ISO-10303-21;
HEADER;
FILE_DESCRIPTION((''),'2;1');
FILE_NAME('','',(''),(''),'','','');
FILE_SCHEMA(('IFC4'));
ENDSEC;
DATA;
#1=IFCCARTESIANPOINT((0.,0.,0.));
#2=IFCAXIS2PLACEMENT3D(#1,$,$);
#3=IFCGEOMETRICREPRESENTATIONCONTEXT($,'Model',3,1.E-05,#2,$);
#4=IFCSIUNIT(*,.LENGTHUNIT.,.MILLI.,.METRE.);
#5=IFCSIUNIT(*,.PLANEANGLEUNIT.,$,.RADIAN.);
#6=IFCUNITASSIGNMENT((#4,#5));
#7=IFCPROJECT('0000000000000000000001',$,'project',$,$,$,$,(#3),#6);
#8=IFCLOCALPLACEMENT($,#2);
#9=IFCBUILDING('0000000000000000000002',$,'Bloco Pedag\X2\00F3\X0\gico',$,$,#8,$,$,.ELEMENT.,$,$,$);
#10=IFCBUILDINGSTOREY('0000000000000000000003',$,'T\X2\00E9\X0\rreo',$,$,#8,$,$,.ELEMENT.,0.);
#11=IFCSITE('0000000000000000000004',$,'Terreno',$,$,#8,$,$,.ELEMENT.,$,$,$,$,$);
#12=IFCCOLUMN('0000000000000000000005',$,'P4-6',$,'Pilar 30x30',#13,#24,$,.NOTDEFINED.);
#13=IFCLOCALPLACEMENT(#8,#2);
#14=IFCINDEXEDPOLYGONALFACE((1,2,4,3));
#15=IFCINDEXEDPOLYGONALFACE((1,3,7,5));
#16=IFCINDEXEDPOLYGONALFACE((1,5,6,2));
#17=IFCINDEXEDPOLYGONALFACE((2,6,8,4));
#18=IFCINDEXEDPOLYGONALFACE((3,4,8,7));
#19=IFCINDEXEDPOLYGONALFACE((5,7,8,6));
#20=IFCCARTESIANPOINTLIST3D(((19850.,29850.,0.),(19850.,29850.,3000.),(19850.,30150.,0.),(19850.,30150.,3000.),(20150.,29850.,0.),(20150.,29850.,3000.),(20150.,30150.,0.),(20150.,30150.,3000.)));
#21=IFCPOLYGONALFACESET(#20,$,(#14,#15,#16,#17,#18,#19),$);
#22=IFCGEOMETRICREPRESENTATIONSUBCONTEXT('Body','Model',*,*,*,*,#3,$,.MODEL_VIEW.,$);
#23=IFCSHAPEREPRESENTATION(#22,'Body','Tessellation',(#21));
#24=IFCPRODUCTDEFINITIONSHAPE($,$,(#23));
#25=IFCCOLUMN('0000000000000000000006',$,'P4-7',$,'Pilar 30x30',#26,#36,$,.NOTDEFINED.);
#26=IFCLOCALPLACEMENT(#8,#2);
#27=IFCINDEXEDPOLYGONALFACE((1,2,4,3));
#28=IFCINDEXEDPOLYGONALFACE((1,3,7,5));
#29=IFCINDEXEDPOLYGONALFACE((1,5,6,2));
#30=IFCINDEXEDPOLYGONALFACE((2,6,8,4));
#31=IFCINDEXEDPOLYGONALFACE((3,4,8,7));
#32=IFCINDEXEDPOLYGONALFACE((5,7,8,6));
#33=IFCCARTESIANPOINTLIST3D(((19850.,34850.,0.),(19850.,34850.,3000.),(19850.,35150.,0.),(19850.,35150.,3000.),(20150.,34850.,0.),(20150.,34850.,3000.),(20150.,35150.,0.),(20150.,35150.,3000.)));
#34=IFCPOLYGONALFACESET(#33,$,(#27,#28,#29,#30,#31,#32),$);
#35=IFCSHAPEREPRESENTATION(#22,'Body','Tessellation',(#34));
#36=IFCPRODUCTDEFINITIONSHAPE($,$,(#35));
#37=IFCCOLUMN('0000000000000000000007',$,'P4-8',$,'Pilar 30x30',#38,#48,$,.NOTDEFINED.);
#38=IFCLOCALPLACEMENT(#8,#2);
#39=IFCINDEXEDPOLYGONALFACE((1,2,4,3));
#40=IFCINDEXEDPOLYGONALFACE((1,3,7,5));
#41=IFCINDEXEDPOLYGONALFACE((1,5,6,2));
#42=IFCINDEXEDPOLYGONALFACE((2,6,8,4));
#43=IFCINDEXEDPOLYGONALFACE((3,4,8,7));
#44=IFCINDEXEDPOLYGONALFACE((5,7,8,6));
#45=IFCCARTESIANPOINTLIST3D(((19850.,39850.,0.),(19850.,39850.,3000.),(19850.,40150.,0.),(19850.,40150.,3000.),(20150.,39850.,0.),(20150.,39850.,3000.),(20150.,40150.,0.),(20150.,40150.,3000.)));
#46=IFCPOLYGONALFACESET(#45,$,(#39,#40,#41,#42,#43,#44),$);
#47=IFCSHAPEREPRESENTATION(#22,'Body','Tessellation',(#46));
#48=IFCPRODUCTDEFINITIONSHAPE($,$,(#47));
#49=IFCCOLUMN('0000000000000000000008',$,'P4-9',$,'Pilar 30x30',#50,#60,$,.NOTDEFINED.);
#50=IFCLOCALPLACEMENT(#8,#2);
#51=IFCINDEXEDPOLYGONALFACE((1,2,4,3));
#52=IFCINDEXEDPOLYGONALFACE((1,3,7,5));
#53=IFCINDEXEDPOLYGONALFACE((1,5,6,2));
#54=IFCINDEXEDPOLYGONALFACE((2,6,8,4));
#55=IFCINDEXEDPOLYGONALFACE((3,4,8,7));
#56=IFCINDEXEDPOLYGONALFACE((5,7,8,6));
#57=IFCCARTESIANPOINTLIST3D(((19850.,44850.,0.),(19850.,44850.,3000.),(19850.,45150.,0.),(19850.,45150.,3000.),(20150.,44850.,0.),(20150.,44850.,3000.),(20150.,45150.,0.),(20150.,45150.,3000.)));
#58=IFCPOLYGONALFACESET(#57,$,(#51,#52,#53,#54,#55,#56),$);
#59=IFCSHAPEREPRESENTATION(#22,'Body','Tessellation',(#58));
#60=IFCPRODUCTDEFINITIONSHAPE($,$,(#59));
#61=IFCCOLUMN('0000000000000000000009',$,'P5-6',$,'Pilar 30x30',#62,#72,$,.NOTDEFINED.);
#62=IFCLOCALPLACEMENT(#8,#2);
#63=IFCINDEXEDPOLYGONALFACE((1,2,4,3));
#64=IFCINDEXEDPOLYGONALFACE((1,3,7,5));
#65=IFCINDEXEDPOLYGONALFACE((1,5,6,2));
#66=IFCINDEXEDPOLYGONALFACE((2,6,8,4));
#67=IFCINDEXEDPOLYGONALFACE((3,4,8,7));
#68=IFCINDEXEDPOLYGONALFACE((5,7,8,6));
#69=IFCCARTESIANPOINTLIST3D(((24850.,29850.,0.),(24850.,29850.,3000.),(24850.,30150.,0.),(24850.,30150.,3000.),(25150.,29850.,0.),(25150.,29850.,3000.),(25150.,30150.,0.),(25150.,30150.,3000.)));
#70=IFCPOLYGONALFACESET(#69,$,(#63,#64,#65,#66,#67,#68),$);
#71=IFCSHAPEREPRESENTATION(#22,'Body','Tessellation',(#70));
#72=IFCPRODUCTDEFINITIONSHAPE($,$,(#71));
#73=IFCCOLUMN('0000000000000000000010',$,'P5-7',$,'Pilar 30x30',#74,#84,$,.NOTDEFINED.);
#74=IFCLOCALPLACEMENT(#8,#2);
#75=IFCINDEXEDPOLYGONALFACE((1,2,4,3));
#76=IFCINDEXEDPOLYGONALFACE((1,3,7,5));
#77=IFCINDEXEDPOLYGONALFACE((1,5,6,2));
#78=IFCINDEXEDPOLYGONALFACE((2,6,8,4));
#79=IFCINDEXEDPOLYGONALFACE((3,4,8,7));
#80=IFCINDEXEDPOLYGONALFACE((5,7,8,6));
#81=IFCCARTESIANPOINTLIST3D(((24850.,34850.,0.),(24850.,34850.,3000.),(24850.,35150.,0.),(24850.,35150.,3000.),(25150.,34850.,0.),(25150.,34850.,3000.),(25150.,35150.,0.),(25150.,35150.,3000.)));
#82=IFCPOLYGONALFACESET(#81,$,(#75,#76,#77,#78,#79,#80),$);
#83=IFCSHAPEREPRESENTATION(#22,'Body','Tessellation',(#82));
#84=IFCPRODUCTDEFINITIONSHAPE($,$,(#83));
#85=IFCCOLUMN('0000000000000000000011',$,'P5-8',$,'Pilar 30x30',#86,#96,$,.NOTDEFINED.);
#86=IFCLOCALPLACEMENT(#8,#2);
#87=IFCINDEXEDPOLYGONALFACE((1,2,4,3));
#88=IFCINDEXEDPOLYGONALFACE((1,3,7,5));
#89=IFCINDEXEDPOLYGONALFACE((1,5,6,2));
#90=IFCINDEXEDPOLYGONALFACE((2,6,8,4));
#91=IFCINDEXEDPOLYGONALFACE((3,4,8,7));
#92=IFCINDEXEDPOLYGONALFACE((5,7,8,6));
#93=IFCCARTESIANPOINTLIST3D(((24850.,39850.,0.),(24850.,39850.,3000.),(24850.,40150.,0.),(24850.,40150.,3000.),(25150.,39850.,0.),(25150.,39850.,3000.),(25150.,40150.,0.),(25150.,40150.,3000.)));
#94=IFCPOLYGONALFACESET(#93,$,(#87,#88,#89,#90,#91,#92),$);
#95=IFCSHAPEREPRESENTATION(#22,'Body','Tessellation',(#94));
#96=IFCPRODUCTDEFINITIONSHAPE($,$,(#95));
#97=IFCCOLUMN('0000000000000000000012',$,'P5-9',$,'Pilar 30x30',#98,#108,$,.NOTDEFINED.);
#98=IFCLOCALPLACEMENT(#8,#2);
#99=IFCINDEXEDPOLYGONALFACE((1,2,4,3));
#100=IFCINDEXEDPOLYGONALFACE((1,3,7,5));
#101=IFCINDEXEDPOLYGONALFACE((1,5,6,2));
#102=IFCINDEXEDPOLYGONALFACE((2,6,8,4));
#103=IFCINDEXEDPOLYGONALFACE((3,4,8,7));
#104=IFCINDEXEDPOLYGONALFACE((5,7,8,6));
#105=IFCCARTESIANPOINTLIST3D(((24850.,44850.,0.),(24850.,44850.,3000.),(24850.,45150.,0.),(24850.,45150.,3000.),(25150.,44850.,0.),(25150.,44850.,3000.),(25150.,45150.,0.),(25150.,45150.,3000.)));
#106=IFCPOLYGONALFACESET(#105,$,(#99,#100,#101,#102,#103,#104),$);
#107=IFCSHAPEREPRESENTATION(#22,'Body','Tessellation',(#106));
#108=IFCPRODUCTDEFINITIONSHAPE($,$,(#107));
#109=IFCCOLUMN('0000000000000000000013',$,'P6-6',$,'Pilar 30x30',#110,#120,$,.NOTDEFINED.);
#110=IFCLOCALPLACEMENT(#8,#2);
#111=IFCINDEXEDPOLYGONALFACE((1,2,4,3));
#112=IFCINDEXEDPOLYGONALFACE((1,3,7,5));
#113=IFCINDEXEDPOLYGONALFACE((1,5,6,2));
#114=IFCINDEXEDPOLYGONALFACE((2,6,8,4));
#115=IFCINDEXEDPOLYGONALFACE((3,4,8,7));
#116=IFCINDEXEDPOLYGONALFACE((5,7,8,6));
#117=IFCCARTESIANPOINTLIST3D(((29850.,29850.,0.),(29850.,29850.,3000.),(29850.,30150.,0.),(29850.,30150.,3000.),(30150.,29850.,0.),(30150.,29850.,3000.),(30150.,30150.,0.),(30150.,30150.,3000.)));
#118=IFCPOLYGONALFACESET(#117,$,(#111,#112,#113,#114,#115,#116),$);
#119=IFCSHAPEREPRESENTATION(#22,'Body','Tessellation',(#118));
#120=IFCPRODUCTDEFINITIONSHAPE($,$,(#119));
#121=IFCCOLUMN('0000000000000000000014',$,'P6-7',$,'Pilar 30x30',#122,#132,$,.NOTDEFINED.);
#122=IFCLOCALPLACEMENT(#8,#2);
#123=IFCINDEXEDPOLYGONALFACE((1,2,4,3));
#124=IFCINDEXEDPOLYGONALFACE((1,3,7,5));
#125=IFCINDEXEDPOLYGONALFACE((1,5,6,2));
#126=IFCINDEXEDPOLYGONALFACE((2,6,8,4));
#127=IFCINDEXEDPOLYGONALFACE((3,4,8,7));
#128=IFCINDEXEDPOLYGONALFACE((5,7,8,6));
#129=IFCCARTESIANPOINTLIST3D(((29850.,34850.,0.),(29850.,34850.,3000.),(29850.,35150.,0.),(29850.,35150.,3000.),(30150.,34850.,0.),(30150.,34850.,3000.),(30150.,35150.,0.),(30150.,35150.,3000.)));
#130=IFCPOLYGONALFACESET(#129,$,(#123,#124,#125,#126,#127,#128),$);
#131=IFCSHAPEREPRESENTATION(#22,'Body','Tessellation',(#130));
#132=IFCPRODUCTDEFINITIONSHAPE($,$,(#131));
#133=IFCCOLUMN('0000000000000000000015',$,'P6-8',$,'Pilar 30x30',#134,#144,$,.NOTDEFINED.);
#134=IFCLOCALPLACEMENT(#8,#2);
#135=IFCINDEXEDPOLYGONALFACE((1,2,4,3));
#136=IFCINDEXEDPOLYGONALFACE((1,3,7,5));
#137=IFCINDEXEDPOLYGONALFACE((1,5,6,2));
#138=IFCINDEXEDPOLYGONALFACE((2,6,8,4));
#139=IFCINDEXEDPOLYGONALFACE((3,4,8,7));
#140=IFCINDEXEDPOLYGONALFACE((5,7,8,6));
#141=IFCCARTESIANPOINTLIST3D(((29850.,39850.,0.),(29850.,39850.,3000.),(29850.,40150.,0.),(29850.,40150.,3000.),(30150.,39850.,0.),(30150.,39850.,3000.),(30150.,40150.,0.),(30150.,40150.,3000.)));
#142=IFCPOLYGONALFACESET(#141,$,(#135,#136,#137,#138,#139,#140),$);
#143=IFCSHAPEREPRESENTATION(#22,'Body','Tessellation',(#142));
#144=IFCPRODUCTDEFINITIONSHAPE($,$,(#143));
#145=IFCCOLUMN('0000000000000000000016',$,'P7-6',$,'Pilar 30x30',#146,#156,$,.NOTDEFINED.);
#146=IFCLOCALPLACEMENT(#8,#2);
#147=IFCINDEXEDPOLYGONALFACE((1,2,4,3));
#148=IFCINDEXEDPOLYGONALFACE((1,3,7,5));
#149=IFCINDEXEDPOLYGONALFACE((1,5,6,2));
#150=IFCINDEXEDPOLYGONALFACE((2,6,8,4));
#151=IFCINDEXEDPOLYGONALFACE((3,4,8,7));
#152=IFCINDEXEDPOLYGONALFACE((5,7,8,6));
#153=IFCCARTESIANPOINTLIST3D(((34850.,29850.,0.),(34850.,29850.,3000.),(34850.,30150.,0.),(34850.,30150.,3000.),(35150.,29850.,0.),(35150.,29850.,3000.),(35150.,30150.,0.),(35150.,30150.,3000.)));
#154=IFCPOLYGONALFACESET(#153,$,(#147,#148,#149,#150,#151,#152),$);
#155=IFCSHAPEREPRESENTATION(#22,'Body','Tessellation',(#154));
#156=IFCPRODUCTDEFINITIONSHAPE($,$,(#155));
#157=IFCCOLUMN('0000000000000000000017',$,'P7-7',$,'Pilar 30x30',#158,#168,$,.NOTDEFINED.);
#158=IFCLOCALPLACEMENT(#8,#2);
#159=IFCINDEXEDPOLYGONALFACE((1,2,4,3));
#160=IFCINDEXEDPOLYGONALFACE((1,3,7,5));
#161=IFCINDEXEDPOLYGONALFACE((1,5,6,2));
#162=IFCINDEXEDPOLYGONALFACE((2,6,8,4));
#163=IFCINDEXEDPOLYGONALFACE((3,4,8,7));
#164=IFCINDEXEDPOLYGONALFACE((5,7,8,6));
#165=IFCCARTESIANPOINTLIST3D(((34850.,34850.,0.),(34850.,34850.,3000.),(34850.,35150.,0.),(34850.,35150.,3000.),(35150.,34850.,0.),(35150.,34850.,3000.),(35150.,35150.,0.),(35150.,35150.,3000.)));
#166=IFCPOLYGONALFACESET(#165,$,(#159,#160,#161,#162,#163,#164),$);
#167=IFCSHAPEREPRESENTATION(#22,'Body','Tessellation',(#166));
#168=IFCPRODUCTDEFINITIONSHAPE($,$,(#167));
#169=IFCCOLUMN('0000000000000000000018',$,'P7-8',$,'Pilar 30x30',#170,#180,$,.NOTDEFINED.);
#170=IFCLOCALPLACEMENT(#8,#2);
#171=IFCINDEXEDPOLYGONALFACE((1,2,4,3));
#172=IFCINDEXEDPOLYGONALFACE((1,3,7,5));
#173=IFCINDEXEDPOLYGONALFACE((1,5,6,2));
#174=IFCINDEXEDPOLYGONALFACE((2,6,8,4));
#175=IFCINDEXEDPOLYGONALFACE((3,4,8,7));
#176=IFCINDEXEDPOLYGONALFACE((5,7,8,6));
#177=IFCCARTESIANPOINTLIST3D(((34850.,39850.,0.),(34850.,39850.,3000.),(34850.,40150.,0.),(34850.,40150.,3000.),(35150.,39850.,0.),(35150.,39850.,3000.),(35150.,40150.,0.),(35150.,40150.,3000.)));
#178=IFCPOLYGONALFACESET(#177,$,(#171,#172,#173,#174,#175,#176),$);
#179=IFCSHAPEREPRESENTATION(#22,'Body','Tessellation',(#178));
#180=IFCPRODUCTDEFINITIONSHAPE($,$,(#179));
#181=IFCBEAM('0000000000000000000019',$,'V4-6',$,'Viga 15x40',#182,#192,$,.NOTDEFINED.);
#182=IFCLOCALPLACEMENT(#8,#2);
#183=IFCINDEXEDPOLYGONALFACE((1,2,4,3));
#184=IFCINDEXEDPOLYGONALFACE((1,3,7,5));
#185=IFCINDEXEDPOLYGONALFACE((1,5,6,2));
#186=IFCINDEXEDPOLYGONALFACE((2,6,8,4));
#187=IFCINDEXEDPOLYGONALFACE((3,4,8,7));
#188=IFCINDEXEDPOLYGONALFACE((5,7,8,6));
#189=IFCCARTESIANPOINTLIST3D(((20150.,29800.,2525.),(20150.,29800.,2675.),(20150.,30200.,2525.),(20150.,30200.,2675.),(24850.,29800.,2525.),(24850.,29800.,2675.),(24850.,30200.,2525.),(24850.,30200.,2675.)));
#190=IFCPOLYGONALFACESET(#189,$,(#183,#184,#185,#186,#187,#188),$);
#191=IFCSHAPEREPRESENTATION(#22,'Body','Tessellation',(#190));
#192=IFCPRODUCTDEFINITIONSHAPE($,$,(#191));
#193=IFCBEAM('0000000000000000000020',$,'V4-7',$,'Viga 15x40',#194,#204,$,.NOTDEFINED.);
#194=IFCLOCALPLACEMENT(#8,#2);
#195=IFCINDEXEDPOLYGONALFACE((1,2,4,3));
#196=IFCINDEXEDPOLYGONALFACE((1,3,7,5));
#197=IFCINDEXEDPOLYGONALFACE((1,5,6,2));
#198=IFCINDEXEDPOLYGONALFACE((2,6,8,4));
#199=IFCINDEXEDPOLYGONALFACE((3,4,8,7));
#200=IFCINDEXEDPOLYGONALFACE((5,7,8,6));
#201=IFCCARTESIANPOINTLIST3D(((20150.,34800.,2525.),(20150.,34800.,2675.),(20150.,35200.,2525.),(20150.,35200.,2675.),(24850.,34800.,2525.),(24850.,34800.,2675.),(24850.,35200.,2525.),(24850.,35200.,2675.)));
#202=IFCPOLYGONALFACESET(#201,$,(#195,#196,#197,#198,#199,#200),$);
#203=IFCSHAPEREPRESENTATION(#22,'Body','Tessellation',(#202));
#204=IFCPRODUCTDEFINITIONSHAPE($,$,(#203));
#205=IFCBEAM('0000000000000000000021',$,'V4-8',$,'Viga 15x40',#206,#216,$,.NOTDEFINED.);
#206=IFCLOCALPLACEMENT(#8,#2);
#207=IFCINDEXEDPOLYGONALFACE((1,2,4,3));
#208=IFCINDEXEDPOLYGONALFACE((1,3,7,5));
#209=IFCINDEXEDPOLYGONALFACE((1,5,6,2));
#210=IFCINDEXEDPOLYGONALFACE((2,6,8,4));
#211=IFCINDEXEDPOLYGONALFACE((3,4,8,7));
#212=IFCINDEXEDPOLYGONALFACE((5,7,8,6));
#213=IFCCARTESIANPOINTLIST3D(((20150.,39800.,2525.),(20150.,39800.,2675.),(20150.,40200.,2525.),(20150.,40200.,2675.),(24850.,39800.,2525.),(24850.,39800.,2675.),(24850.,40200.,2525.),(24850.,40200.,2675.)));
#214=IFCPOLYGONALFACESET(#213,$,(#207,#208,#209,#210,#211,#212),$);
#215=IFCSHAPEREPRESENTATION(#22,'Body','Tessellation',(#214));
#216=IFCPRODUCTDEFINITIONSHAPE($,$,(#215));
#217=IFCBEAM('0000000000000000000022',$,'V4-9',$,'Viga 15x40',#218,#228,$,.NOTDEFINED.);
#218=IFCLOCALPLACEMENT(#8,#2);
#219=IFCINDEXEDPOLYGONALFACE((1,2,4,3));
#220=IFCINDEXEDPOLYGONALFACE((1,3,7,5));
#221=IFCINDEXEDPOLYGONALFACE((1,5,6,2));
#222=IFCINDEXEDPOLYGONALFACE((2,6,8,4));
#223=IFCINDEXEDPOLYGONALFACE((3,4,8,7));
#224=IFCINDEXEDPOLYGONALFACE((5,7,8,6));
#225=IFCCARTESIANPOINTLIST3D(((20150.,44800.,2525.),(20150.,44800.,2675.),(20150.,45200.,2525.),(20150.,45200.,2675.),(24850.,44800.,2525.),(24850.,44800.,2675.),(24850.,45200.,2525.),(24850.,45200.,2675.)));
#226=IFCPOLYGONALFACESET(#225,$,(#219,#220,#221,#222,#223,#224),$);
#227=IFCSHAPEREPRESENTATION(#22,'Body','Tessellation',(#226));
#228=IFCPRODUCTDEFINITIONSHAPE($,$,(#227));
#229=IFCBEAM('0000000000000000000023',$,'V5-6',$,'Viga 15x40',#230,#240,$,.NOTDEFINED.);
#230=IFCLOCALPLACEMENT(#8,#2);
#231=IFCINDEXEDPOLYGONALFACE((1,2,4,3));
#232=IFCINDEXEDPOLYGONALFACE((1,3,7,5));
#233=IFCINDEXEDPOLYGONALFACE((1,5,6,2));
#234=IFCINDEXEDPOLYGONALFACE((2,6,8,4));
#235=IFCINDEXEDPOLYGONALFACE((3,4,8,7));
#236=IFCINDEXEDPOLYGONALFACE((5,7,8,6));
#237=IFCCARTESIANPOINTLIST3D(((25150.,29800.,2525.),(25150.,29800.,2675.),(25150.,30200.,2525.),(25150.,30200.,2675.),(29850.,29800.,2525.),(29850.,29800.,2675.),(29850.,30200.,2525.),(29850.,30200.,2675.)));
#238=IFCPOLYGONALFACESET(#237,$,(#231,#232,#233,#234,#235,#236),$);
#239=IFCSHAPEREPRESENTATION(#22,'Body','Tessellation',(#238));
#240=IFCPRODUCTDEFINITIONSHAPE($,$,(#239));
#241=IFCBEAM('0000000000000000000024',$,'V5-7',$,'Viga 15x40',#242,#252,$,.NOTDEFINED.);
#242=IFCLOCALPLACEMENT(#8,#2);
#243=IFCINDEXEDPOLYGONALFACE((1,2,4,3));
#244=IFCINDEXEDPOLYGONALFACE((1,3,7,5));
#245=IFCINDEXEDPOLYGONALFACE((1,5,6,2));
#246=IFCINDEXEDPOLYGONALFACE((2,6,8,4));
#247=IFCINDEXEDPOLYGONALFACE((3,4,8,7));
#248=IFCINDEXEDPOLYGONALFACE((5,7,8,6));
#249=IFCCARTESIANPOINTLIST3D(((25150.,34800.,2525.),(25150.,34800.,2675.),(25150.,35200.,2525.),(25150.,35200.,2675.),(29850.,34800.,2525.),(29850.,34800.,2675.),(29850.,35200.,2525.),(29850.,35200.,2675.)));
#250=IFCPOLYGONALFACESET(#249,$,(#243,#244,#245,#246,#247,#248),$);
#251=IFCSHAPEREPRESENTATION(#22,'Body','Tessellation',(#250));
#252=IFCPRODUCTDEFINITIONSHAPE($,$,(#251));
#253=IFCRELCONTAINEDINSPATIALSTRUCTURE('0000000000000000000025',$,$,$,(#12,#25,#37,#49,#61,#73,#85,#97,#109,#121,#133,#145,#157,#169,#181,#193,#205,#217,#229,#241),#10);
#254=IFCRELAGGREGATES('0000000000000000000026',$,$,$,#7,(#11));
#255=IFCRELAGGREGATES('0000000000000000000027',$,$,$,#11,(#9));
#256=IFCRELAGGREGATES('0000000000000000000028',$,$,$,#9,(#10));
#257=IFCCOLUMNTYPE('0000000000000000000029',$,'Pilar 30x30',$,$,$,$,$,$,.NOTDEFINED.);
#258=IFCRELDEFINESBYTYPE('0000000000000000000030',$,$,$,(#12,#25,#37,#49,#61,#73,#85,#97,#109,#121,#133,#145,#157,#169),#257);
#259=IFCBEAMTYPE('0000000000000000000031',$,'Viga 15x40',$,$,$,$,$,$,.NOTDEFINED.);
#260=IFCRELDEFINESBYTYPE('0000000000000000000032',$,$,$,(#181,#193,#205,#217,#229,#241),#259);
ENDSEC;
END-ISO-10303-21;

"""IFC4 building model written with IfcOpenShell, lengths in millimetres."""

from ifc_helpers import new_model, si_unit, frame, origin, origin_2d, place, context, subcontext, project, spatial, rectangle, extrude, type_object, element, save


model = new_model("IFC4")

# Units and contexts
model_context = context("Model", 3, precision=1e-05, world=origin())
body_context = subcontext(model_context, "Body", "Model", "MODEL_VIEW")
ifc_project = project(units=[si_unit("LENGTHUNIT", "METRE", prefix="MILLI"), si_unit("PLANEANGLEUNIT", "RADIAN")], contexts=[model_context])

# Site, building, storey
placement = place(None, origin())
site = spatial("IfcSite", under=ifc_project, at=placement, Name="Terreno", CompositionType="ELEMENT")
building = spatial("IfcBuilding", under=site, at=placement, Name="Bloco Pedagógico", CompositionType="ELEMENT")
storey = spatial("IfcBuildingStorey", under=building, at=placement, Name="Térreo", CompositionType="ELEMENT", Elevation=0.0)

# Columns
column_type = type_object("IfcColumnType", Name="Pilar 30x30", PredefinedType="NOTDEFINED")
for number, where, z_axis, x_axis, name in (
    (1, (20000.0, 30000.0, 0.0), (0.0, 0.0, 1.0), (1.0, 0.0, 0.0), "P4-6"),
    (2, (20000.0, 35000.0, 0.0), (0.0, 0.0, 1.0), (1.0, 0.0, 0.0), "P4-7"),
    (3, (20000.0, 40000.0, 0.0), (0.0, 0.0, 1.0), (1.0, 0.0, 0.0), "P4-8"),
    (4, (20000.0, 45000.0, 0.0), (0.0, 0.0, 1.0), (1.0, 0.0, 0.0), "P4-9"),
    (5, (25000.0, 30000.0, 0.0), (0.0, 0.0, 1.0), (1.0, 0.0, 0.0), "P5-6"),
    (6, (25000.0, 35000.0, 0.0), (0.0, 0.0, 1.0), (1.0, 0.0, 0.0), "P5-7"),
    (7, (25000.0, 40000.0, 0.0), (0.0, 0.0, 1.0), (1.0, 0.0, 0.0), "P5-8"),
    (8, (25000.0, 45000.0, 0.0), (0.0, 0.0, 1.0), (1.0, 0.0, 0.0), "P5-9"),
    (9, (30000.0, 30000.0, 0.0), (0.0, 0.0, 1.0), (1.0, 0.0, 0.0), "P6-6"),
    (10, (30000.0, 35000.0, 0.0), (0.0, 0.0, 1.0), (1.0, 0.0, 0.0), "P6-7"),
    (11, (30000.0, 40000.0, 0.0), (0.0, 0.0, 1.0), (1.0, 0.0, 0.0), "P6-8"),
    (12, (35000.0, 30000.0, 0.0), (0.0, 0.0, 1.0), (1.0, 0.0, 0.0), "P7-6"),
    (13, (35000.0, 35000.0, 0.0), (0.0, 0.0, 1.0), (1.0, 0.0, 0.0), "P7-7"),
    (14, (35000.0, 40000.0, 0.0), (0.0, 0.0, 1.0), (1.0, 0.0, 0.0), "P7-8"),
):
    element("IfcColumn", number, at=place(None, frame(where, z_axis=z_axis, x_axis=x_axis)), inside=storey, type_object=column_type, Name=name, ObjectType="Pilar 30x30", PredefinedType="NOTDEFINED", context=body_context, shape_type="SweptSolid", body=[
        extrude(rectangle(XDim=300.0, YDim=300.0, at=origin_2d()), None, (0.0, 0.0, 1.0), 3000.0),
    ])

# Beams
beam_type = type_object("IfcBeamType", Name="Viga 15x40", PredefinedType="NOTDEFINED")
for number, where, z_axis, x_axis, name in (
    (15, (20150.0, 30000.0, 2600.0), (1.0, 0.0, 0.0), (0.0, 1.0, 0.0), "V4-6"),
    (16, (20150.0, 35000.0, 2600.0), (1.0, 0.0, 0.0), (0.0, 1.0, 0.0), "V4-7"),
    (17, (20150.0, 40000.0, 2600.0), (1.0, 0.0, 0.0), (0.0, 1.0, 0.0), "V4-8"),
    (18, (20150.0, 45000.0, 2600.0), (1.0, 0.0, 0.0), (0.0, 1.0, 0.0), "V4-9"),
    (19, (25150.0, 30000.0, 2600.0), (1.0, 0.0, 0.0), (0.0, 1.0, 0.0), "V5-6"),
    (20, (25150.0, 35000.0, 2600.0), (1.0, 0.0, 0.0), (0.0, 1.0, 0.0), "V5-7"),
):
    element("IfcBeam", number, at=place(None, frame(where, z_axis=z_axis, x_axis=x_axis)), inside=storey, type_object=beam_type, Name=name, ObjectType="Viga 15x40", PredefinedType="NOTDEFINED", context=body_context, shape_type="SweptSolid", body=[
        extrude(rectangle(XDim=400.0, YDim=150.0, at=origin_2d()), None, (0.0, 0.0, 1.0), 4700.0),
    ])

save(model, "model.ifc")
